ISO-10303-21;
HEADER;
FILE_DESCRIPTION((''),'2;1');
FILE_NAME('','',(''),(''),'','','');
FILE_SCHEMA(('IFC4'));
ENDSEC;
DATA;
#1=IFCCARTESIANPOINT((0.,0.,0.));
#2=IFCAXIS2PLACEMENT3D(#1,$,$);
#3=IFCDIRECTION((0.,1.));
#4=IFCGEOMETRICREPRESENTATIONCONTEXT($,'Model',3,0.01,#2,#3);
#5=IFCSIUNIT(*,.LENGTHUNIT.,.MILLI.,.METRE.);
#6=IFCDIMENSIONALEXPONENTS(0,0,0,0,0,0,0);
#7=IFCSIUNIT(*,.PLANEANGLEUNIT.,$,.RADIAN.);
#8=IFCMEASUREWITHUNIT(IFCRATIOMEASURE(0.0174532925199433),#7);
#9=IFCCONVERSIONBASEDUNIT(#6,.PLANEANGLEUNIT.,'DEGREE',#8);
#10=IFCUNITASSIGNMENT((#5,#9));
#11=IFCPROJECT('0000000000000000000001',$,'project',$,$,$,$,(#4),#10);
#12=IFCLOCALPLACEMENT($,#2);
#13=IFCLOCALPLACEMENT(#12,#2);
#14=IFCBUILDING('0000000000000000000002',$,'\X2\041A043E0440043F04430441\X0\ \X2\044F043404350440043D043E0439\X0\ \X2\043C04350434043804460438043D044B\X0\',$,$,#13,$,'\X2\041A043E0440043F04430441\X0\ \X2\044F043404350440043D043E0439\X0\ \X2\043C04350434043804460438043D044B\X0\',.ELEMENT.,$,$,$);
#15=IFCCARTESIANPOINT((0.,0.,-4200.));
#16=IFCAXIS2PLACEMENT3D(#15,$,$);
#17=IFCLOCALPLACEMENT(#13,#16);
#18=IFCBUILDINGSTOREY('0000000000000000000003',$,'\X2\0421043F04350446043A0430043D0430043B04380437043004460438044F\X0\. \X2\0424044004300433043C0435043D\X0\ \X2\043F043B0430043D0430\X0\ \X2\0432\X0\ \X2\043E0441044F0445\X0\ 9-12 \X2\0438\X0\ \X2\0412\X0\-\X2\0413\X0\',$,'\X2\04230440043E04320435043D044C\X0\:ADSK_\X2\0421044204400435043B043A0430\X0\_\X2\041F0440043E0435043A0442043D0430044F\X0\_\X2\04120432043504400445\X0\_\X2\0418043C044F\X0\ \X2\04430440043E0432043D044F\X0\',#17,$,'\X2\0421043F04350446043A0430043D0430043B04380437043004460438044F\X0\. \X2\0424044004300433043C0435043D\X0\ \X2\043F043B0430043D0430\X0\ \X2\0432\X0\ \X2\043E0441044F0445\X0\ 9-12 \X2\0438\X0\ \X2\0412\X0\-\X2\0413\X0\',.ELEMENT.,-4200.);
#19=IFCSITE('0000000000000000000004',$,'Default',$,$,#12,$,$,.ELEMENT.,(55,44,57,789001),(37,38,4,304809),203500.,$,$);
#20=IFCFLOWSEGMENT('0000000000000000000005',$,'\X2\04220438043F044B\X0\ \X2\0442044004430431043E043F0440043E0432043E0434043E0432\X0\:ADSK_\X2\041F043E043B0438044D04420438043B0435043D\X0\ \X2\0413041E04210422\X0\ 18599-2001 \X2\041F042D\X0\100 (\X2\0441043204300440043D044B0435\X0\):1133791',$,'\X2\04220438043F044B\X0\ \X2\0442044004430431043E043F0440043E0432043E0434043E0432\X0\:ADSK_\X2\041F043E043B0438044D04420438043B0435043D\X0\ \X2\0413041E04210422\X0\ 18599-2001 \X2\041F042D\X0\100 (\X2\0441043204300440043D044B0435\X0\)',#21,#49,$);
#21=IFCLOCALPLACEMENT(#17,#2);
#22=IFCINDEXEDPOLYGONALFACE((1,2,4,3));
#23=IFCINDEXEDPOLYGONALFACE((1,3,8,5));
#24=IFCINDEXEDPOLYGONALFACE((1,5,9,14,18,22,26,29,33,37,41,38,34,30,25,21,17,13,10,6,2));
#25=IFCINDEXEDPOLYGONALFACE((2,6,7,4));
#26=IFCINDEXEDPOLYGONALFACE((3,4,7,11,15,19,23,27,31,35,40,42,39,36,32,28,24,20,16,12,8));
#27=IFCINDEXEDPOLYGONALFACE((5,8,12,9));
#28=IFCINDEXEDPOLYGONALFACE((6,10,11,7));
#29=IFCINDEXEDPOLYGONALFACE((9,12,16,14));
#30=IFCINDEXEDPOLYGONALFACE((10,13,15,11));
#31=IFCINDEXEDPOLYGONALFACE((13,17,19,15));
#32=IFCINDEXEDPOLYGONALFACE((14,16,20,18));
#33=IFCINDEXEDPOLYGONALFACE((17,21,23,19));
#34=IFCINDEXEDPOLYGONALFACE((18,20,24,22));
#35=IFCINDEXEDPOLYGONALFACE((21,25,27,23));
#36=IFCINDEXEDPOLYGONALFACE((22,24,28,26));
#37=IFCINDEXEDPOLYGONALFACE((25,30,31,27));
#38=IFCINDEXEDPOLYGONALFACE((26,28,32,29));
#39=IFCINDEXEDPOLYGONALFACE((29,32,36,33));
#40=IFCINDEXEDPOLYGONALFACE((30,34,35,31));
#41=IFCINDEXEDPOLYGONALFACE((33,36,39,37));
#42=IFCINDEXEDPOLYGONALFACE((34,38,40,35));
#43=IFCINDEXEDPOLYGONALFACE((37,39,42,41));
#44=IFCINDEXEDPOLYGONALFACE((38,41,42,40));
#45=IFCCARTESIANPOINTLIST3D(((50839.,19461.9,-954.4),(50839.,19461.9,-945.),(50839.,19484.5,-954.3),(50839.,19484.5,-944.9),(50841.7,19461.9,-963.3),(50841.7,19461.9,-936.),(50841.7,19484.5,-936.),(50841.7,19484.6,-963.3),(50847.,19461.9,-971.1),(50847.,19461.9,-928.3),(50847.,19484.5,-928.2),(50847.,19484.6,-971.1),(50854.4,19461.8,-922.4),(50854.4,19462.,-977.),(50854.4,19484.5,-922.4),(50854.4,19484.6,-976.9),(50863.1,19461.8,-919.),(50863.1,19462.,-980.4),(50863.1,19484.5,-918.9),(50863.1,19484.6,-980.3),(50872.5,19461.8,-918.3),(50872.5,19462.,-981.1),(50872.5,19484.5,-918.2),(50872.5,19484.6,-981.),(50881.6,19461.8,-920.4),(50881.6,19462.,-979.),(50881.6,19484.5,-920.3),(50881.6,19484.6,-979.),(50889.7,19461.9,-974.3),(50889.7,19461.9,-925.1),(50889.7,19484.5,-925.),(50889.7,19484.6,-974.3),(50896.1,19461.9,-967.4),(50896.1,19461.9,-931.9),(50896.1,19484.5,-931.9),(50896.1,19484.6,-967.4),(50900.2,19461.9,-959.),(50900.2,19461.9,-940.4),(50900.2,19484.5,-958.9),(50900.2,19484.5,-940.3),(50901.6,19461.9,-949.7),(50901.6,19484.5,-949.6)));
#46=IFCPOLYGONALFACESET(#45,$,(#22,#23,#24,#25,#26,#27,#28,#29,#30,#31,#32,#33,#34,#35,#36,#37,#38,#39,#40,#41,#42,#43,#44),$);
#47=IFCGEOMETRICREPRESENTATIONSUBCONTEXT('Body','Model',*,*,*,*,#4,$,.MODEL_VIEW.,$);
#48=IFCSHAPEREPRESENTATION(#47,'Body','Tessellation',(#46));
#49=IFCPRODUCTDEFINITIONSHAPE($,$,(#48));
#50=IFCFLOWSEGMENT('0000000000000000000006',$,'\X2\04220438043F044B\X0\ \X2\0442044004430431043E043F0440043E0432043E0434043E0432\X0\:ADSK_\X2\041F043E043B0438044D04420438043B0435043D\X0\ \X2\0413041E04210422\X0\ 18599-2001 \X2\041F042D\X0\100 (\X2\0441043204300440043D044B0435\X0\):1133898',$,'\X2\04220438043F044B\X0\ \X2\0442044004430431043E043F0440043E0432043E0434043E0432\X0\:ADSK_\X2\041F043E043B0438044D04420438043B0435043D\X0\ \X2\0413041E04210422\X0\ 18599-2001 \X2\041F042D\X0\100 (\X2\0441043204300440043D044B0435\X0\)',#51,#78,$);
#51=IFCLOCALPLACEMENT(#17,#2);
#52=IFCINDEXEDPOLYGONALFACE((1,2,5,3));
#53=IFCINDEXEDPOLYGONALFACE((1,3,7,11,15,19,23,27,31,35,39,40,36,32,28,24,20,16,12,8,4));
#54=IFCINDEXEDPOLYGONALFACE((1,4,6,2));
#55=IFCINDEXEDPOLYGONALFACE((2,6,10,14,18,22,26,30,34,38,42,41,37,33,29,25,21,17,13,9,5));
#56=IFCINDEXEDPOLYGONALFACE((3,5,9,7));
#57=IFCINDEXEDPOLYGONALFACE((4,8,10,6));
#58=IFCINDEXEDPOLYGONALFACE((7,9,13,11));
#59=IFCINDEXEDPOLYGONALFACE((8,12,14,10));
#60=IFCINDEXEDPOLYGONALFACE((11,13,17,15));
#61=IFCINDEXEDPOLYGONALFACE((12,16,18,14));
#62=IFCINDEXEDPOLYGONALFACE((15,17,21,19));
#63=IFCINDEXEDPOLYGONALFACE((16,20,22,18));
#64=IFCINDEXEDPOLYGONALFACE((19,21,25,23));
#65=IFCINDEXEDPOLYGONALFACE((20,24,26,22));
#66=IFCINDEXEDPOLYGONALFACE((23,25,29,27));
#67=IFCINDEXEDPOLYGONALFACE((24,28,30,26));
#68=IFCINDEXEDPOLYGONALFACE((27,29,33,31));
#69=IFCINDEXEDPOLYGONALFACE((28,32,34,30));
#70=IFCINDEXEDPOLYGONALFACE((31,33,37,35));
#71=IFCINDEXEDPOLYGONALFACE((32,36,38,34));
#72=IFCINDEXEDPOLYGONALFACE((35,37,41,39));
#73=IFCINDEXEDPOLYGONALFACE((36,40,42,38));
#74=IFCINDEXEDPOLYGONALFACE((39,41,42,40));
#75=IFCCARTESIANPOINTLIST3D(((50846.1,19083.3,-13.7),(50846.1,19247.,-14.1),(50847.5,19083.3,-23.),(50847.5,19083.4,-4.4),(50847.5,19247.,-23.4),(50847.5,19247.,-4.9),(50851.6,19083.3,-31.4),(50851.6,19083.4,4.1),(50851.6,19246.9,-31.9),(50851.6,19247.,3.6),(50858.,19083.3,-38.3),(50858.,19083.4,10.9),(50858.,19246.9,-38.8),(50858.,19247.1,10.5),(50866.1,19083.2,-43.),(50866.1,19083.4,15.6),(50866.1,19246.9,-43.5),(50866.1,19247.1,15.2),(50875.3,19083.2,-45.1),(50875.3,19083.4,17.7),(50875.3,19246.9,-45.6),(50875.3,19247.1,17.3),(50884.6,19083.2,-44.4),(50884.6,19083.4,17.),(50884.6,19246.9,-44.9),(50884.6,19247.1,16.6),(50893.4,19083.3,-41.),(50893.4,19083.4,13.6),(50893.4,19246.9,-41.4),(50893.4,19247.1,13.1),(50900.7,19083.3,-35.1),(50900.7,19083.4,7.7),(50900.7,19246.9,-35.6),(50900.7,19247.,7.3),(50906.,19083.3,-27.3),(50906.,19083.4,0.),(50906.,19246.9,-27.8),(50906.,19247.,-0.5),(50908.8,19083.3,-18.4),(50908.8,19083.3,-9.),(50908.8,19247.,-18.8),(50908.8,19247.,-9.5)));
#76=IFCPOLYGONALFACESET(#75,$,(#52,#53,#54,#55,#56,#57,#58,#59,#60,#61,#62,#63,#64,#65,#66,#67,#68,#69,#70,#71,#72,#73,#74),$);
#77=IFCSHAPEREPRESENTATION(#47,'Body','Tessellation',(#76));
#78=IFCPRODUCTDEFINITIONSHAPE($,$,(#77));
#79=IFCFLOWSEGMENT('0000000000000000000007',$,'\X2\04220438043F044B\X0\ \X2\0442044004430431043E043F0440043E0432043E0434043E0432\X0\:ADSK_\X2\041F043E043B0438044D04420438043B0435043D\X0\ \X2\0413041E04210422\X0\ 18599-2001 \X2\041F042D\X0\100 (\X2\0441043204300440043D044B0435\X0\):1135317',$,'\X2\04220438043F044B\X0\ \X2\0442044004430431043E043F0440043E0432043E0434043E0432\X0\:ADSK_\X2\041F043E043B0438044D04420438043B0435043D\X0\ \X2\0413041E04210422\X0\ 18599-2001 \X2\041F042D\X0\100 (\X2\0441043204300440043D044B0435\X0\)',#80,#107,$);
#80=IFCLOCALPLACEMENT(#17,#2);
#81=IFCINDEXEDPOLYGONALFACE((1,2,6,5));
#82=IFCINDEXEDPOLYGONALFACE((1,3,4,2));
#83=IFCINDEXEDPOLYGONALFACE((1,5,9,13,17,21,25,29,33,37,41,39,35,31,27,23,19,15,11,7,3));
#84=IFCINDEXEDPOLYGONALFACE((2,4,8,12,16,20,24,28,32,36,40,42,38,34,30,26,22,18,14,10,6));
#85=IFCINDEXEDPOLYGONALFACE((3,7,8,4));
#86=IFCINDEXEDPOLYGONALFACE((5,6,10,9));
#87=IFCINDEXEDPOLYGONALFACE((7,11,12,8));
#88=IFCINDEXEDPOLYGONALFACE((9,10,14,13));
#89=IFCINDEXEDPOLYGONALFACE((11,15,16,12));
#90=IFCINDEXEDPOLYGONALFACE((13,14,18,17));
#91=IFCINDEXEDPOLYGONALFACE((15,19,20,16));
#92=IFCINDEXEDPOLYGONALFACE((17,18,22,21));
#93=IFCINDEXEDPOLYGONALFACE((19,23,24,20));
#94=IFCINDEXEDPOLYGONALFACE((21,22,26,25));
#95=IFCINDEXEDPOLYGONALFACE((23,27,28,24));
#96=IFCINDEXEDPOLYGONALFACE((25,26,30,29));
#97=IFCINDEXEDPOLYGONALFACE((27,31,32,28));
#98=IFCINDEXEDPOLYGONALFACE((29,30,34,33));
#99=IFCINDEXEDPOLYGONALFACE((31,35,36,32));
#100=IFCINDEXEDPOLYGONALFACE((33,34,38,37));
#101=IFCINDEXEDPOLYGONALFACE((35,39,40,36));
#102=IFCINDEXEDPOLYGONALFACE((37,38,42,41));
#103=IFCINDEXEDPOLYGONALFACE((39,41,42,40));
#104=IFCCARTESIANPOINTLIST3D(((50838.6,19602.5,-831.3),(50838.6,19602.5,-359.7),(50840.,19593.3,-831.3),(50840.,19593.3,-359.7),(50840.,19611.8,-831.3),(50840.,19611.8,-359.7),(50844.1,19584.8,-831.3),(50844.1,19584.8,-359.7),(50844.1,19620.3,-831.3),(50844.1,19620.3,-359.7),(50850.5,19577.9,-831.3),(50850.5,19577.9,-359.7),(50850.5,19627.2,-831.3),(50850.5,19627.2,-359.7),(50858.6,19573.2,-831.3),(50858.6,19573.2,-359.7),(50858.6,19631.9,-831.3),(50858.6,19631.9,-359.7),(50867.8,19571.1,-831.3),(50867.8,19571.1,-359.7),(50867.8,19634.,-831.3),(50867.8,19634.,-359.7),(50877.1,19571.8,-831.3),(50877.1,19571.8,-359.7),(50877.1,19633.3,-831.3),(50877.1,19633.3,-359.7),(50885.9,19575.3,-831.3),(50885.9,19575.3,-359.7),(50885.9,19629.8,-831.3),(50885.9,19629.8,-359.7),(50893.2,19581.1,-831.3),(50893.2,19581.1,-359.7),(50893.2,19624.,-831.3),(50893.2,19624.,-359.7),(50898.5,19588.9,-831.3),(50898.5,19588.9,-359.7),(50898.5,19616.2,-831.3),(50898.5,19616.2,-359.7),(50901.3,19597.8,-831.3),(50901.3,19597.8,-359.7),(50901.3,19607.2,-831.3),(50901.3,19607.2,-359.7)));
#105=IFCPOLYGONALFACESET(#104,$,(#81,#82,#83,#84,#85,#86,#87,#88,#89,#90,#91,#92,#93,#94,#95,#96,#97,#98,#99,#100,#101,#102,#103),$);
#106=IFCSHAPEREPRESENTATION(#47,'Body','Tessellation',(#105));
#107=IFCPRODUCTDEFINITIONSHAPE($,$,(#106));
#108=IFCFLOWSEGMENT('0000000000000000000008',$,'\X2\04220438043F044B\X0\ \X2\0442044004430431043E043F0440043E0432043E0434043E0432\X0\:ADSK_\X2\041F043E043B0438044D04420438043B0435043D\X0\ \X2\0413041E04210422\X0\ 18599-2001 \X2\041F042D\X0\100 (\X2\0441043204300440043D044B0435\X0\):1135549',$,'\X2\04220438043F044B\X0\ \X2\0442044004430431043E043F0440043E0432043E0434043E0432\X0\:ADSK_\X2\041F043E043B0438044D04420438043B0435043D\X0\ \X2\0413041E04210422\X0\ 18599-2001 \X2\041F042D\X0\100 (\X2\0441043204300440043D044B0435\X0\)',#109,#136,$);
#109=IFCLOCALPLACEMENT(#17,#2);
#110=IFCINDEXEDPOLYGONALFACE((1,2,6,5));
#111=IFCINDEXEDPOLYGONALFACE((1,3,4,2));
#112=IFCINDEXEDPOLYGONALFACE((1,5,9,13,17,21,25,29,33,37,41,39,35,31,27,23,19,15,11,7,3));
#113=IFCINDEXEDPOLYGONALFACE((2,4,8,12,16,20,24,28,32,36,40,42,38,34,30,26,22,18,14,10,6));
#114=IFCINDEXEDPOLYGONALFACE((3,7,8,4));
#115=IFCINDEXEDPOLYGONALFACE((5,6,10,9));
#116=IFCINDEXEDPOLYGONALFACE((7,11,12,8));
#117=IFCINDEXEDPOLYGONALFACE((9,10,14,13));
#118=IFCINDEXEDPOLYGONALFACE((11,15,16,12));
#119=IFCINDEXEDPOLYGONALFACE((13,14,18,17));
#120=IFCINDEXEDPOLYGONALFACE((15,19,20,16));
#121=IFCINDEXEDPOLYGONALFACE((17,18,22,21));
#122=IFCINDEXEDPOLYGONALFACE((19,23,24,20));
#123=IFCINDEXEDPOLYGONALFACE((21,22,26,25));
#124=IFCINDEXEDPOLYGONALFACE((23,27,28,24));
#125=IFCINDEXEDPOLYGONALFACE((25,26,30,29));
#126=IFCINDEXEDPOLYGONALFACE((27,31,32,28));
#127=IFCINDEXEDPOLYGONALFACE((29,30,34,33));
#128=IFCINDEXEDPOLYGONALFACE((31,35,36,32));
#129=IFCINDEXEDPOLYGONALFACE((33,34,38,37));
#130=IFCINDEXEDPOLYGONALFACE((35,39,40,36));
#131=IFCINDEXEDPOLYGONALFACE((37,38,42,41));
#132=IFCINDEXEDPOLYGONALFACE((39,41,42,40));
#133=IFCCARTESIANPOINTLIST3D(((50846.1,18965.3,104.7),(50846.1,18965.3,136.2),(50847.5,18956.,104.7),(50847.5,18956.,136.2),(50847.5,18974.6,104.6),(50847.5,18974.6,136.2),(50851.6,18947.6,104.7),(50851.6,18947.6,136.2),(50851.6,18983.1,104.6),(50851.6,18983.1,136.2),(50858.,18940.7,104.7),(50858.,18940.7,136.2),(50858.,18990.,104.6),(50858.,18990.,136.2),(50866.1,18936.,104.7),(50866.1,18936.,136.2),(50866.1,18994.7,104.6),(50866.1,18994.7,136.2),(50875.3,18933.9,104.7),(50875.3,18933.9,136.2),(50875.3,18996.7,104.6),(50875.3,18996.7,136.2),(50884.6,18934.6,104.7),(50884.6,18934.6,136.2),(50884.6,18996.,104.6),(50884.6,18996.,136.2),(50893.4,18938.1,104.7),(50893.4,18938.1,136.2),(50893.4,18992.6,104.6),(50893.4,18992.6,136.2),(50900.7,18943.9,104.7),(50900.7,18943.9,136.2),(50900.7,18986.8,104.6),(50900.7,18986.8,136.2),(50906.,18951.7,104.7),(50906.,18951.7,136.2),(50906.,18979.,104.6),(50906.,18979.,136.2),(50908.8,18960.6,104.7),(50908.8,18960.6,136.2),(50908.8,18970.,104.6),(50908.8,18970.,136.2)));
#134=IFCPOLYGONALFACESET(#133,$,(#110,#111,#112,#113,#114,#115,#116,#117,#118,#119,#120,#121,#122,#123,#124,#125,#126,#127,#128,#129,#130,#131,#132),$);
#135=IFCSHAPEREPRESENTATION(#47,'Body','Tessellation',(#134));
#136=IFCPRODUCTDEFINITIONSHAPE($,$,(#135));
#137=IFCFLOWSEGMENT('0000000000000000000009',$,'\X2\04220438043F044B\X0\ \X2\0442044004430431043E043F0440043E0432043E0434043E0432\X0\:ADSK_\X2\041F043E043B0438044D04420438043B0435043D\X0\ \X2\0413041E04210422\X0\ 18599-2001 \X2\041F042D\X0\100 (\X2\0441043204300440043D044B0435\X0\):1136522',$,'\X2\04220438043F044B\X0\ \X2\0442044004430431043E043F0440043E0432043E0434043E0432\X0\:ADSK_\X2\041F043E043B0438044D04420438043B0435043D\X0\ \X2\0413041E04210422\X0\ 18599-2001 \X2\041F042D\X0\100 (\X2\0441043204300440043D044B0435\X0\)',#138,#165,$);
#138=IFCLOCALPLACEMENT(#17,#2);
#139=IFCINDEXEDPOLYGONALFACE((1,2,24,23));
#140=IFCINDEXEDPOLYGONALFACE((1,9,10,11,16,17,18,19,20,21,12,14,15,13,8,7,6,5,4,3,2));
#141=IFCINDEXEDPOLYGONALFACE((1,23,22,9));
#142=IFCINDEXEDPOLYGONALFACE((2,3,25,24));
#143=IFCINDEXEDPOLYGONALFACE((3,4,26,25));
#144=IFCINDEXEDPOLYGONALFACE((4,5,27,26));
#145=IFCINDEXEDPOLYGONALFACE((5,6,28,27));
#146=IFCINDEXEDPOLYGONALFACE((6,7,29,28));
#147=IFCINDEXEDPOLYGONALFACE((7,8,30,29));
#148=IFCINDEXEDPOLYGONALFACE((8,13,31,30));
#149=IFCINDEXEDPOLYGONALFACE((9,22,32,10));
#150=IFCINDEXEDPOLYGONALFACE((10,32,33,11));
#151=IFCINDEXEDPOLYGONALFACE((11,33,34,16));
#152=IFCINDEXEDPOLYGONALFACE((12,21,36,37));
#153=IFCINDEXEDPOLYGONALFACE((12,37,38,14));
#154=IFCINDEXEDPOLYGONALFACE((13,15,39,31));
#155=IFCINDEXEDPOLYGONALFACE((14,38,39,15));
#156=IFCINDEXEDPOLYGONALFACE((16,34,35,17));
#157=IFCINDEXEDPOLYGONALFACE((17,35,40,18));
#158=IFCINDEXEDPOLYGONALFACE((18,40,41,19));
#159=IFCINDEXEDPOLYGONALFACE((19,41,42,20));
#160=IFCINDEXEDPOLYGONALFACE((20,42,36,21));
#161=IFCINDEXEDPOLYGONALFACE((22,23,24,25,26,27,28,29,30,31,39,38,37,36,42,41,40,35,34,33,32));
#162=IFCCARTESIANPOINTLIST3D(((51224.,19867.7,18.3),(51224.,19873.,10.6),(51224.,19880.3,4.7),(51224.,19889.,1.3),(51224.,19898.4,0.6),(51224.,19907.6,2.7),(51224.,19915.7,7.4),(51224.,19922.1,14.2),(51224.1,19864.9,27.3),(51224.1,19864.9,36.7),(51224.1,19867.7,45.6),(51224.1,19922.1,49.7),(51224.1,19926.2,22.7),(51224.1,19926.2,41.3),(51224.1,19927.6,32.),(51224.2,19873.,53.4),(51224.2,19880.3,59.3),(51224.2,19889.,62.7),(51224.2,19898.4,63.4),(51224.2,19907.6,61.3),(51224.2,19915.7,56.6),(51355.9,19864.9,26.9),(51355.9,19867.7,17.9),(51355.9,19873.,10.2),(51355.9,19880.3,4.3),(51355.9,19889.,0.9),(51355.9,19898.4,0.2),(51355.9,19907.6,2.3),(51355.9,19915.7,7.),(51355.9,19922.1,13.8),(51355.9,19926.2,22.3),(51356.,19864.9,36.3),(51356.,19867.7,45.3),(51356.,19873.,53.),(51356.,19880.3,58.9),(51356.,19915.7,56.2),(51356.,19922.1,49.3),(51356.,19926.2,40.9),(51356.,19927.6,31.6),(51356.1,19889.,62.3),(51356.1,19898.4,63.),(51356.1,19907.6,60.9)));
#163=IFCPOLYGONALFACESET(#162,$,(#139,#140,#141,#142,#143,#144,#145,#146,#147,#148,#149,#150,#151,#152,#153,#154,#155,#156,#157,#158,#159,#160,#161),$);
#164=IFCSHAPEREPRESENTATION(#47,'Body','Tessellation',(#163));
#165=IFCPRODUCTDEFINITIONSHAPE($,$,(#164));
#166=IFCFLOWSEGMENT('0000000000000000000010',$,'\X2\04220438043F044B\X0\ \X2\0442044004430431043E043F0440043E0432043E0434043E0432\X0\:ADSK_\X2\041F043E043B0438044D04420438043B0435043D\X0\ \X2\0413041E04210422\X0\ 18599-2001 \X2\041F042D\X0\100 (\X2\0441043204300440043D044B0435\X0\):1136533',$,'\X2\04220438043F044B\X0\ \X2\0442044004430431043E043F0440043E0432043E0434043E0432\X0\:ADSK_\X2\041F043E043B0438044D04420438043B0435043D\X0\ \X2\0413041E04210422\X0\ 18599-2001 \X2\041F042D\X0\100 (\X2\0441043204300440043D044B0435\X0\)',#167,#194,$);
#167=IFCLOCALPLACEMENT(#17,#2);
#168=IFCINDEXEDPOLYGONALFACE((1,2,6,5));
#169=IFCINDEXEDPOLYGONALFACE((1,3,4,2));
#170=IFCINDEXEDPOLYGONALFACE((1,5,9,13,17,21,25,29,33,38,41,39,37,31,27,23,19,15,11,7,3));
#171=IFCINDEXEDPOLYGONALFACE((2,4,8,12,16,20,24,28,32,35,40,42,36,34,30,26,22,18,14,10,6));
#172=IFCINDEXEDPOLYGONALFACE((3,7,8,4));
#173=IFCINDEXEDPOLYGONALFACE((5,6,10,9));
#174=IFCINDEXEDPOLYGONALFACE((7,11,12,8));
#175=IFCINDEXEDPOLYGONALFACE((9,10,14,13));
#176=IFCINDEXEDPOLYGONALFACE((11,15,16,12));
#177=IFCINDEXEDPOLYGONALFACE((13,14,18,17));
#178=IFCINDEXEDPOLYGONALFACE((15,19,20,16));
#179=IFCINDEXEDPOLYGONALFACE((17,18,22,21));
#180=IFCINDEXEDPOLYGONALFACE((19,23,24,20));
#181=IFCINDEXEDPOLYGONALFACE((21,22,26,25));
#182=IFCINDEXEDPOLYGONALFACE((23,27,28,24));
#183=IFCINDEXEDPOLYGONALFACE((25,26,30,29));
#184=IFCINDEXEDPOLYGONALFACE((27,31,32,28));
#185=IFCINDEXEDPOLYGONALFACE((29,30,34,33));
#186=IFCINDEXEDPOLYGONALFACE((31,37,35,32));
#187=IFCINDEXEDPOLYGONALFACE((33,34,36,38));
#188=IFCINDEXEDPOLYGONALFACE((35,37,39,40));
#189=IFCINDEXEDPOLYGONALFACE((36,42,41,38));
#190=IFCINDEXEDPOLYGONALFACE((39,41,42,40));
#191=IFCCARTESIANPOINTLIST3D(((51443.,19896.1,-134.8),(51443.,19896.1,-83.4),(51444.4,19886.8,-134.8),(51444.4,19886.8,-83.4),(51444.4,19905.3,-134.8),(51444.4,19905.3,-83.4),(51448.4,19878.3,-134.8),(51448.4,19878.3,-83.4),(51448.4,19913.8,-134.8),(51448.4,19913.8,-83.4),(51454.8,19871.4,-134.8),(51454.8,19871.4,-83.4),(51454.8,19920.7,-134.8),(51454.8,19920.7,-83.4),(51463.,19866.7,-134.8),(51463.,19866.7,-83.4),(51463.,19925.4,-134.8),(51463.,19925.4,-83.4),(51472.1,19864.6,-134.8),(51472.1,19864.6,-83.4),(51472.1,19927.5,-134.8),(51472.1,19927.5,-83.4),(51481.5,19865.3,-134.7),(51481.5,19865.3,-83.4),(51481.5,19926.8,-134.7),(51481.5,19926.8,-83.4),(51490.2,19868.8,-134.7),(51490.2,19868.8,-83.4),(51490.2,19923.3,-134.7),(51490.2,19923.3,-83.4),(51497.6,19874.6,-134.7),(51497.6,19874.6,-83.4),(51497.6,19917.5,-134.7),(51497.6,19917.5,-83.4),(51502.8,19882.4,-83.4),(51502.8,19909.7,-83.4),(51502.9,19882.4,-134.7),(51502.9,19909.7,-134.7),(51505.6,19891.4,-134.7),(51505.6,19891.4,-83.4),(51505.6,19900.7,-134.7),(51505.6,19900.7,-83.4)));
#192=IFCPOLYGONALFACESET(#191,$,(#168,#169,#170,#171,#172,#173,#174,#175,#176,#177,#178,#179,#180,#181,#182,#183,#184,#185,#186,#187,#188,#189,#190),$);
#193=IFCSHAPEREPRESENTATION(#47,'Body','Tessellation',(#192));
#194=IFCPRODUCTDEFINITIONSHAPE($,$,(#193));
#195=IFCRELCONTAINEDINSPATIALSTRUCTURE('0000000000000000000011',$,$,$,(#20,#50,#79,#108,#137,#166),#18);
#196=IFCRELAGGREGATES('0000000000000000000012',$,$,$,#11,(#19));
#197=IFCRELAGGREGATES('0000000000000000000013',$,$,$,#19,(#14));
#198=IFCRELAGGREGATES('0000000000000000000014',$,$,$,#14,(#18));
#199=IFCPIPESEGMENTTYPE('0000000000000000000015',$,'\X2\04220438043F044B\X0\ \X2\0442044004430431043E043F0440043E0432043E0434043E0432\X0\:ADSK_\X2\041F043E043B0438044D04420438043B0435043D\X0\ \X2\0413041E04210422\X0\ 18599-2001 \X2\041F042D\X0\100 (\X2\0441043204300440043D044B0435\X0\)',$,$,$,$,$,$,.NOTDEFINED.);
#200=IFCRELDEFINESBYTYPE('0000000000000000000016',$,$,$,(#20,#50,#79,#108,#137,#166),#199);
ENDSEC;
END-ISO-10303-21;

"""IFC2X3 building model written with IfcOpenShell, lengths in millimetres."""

from ifc_helpers import new_model, entity, si_unit, converted_unit, direction, frame, origin, origin_2d_with_axis, place, context, subcontext, project, spatial, circle, extrude, type_object, element, save


model = new_model("IFC2X3")

# Units and contexts
model_context = context("Model", 3, precision=0.01, world=origin(), true_north=direction((0.0, 1.0)))
body_context = subcontext(model_context, "Body", "Model", "MODEL_VIEW")
ifc_project = project(units=[si_unit("LENGTHUNIT", "METRE", prefix="MILLI"), converted_unit("PLANEANGLEUNIT", "DEGREE", entity("IfcRatioMeasure", 0.0174532925199433), si_unit("PLANEANGLEUNIT", "RADIAN"), dimensions=[0, 0, 0, 0, 0, 0, 0])], contexts=[model_context])

# Site, building, storey
site_placement = place(None, origin())
site = spatial("IfcSite", under=ifc_project, at=site_placement, Name="Default", CompositionType="ELEMENT", RefLatitude=(55, 44, 57, 789001), RefLongitude=(37, 38, 4, 304809), RefElevation=203500.0)
building_placement = place(site_placement, origin())
building = spatial("IfcBuilding", under=site, at=building_placement, Name="Корпус ядерной медицины", LongName="Корпус ядерной медицины", CompositionType="ELEMENT")
storey_placement = place(building_placement, frame((0.0, 0.0, -4200.0)))
storey = spatial("IfcBuildingStorey", under=building, at=storey_placement, Name="Спецканализация. Фрагмен плана в осях 9-12 и В-Г", ObjectType="Уровень:ADSK_Стрелка_Проектная_Вверх_Имя уровня", LongName="Спецканализация. Фрагмен плана в осях 9-12 и В-Г", CompositionType="ELEMENT", Elevation=-4200.0)

# Flow segments
pipe_segment_type = type_object("IfcPipeSegmentType", Name="Типы трубопроводов:ADSK_Полиэтилен ГОСТ 18599-2001 ПЭ100 (сварные)", PredefinedType="NOTDEFINED")
flow_segment_1_placement = place(storey_placement, frame((50837.0, 19461.8, -982.8)))
element("IfcFlowSegment", 1, at=flow_segment_1_placement, inside=storey, type_object=pipe_segment_type, Name="Типы трубопроводов:ADSK_Полиэтилен ГОСТ 18599-2001 ПЭ100 (сварные):1133791", ObjectType="Типы трубопроводов:ADSK_Полиэтилен ГОСТ 18599-2001 ПЭ100 (сварные)", context=body_context, shape_type="SweptSolid", body=[
    extrude(circle(Radius=31.5, at=origin_2d_with_axis()), frame((33.1, 0.1, 33.1), z_axis=(0.0, 0.999998, 0.002), x_axis=(1.0, 0.0, 0.0)), (0.0, 0.0, 1.0), 22.6),
])
flow_segment_2_placement = place(storey_placement, frame((50844.5, 19083.2, -47.2)))
element("IfcFlowSegment", 2, at=flow_segment_2_placement, inside=storey, type_object=pipe_segment_type, Name="Типы трубопроводов:ADSK_Полиэтилен ГОСТ 18599-2001 ПЭ100 (сварные):1133898", ObjectType="Типы трубопроводов:ADSK_Полиэтилен ГОСТ 18599-2001 ПЭ100 (сварные)", context=body_context, shape_type="SweptSolid", body=[
    extrude(circle(Radius=31.5, at=origin_2d_with_axis()), frame((33.1, 0.1, 33.6), z_axis=(0.0, 0.999996, -0.002852), x_axis=(-1.0, 0.0, 0.0)), (0.0, 0.0, 1.0), 163.7),
])
flow_segment_3_placement = place(storey_placement, frame((50837.0, 19569.4, -831.3)))
element("IfcFlowSegment", 3, at=flow_segment_3_placement, inside=storey, type_object=pipe_segment_type, Name="Типы трубопроводов:ADSK_Полиэтилен ГОСТ 18599-2001 ПЭ100 (сварные):1135317", ObjectType="Типы трубопроводов:ADSK_Полиэтилен ГОСТ 18599-2001 ПЭ100 (сварные)", context=body_context, shape_type="SweptSolid", body=[
    extrude(circle(Radius=31.5, at=origin_2d_with_axis()), frame((33.1, 33.1, 0.0), z_axis=(0.0, 0.000004, 1.0), x_axis=(-1.0, 0.0, 0.0)), (0.0, 0.0, 1.0), 471.6),
])
flow_segment_4_placement = place(storey_placement, frame((50844.5, 18932.2, 104.7)))
element("IfcFlowSegment", 4, at=flow_segment_4_placement, inside=storey, type_object=pipe_segment_type, Name="Типы трубопроводов:ADSK_Полиэтилен ГОСТ 18599-2001 ПЭ100 (сварные):1135549", ObjectType="Типы трубопроводов:ADSK_Полиэтилен ГОСТ 18599-2001 ПЭ100 (сварные)", context=body_context, shape_type="SweptSolid", body=[
    extrude(circle(Radius=31.5, at=origin_2d_with_axis()), frame((33.1, 33.1, 0.0), z_axis=(0.0, 0.00001, 1.0), x_axis=(-1.0, 0.0, 0.0)), (0.0, 0.0, 1.0), 31.6),
])
flow_segment_5_placement = place(storey_placement, frame((51224.0, 19863.0, -1.5)))
element("IfcFlowSegment", 5, at=flow_segment_5_placement, inside=storey, type_object=pipe_segment_type, Name="Типы трубопроводов:ADSK_Полиэтилен ГОСТ 18599-2001 ПЭ100 (сварные):1136522", ObjectType="Типы трубопроводов:ADSK_Полиэтилен ГОСТ 18599-2001 ПЭ100 (сварные)", context=body_context, shape_type="SweptSolid", body=[
    extrude(circle(Radius=31.5, at=origin_2d_with_axis()), frame((0.1, 33.1, 33.5), z_axis=(0.999996, 0.0, -0.002981), x_axis=(0.0, 1.0, 0.0)), (0.0, 0.0, 1.0), 131.9),
])
flow_segment_6_placement = place(storey_placement, frame((51441.4, 19863.0, -134.8)))
element("IfcFlowSegment", 6, at=flow_segment_6_placement, inside=storey, type_object=pipe_segment_type, Name="Типы трубопроводов:ADSK_Полиэтилен ГОСТ 18599-2001 ПЭ100 (сварные):1136533", ObjectType="Типы трубопроводов:ADSK_Полиэтилен ГОСТ 18599-2001 ПЭ100 (сварные)", context=body_context, shape_type="SweptSolid", body=[
    extrude(circle(Radius=31.5, at=origin_2d_with_axis()), frame((33.1, 33.1, 0.0), z_axis=(-0.000012, 0.0, 1.0), x_axis=(-1.0, 0.0, -0.000012)), (0.0, 0.0, 1.0), 51.3),
])

save(model, "model.ifc")
